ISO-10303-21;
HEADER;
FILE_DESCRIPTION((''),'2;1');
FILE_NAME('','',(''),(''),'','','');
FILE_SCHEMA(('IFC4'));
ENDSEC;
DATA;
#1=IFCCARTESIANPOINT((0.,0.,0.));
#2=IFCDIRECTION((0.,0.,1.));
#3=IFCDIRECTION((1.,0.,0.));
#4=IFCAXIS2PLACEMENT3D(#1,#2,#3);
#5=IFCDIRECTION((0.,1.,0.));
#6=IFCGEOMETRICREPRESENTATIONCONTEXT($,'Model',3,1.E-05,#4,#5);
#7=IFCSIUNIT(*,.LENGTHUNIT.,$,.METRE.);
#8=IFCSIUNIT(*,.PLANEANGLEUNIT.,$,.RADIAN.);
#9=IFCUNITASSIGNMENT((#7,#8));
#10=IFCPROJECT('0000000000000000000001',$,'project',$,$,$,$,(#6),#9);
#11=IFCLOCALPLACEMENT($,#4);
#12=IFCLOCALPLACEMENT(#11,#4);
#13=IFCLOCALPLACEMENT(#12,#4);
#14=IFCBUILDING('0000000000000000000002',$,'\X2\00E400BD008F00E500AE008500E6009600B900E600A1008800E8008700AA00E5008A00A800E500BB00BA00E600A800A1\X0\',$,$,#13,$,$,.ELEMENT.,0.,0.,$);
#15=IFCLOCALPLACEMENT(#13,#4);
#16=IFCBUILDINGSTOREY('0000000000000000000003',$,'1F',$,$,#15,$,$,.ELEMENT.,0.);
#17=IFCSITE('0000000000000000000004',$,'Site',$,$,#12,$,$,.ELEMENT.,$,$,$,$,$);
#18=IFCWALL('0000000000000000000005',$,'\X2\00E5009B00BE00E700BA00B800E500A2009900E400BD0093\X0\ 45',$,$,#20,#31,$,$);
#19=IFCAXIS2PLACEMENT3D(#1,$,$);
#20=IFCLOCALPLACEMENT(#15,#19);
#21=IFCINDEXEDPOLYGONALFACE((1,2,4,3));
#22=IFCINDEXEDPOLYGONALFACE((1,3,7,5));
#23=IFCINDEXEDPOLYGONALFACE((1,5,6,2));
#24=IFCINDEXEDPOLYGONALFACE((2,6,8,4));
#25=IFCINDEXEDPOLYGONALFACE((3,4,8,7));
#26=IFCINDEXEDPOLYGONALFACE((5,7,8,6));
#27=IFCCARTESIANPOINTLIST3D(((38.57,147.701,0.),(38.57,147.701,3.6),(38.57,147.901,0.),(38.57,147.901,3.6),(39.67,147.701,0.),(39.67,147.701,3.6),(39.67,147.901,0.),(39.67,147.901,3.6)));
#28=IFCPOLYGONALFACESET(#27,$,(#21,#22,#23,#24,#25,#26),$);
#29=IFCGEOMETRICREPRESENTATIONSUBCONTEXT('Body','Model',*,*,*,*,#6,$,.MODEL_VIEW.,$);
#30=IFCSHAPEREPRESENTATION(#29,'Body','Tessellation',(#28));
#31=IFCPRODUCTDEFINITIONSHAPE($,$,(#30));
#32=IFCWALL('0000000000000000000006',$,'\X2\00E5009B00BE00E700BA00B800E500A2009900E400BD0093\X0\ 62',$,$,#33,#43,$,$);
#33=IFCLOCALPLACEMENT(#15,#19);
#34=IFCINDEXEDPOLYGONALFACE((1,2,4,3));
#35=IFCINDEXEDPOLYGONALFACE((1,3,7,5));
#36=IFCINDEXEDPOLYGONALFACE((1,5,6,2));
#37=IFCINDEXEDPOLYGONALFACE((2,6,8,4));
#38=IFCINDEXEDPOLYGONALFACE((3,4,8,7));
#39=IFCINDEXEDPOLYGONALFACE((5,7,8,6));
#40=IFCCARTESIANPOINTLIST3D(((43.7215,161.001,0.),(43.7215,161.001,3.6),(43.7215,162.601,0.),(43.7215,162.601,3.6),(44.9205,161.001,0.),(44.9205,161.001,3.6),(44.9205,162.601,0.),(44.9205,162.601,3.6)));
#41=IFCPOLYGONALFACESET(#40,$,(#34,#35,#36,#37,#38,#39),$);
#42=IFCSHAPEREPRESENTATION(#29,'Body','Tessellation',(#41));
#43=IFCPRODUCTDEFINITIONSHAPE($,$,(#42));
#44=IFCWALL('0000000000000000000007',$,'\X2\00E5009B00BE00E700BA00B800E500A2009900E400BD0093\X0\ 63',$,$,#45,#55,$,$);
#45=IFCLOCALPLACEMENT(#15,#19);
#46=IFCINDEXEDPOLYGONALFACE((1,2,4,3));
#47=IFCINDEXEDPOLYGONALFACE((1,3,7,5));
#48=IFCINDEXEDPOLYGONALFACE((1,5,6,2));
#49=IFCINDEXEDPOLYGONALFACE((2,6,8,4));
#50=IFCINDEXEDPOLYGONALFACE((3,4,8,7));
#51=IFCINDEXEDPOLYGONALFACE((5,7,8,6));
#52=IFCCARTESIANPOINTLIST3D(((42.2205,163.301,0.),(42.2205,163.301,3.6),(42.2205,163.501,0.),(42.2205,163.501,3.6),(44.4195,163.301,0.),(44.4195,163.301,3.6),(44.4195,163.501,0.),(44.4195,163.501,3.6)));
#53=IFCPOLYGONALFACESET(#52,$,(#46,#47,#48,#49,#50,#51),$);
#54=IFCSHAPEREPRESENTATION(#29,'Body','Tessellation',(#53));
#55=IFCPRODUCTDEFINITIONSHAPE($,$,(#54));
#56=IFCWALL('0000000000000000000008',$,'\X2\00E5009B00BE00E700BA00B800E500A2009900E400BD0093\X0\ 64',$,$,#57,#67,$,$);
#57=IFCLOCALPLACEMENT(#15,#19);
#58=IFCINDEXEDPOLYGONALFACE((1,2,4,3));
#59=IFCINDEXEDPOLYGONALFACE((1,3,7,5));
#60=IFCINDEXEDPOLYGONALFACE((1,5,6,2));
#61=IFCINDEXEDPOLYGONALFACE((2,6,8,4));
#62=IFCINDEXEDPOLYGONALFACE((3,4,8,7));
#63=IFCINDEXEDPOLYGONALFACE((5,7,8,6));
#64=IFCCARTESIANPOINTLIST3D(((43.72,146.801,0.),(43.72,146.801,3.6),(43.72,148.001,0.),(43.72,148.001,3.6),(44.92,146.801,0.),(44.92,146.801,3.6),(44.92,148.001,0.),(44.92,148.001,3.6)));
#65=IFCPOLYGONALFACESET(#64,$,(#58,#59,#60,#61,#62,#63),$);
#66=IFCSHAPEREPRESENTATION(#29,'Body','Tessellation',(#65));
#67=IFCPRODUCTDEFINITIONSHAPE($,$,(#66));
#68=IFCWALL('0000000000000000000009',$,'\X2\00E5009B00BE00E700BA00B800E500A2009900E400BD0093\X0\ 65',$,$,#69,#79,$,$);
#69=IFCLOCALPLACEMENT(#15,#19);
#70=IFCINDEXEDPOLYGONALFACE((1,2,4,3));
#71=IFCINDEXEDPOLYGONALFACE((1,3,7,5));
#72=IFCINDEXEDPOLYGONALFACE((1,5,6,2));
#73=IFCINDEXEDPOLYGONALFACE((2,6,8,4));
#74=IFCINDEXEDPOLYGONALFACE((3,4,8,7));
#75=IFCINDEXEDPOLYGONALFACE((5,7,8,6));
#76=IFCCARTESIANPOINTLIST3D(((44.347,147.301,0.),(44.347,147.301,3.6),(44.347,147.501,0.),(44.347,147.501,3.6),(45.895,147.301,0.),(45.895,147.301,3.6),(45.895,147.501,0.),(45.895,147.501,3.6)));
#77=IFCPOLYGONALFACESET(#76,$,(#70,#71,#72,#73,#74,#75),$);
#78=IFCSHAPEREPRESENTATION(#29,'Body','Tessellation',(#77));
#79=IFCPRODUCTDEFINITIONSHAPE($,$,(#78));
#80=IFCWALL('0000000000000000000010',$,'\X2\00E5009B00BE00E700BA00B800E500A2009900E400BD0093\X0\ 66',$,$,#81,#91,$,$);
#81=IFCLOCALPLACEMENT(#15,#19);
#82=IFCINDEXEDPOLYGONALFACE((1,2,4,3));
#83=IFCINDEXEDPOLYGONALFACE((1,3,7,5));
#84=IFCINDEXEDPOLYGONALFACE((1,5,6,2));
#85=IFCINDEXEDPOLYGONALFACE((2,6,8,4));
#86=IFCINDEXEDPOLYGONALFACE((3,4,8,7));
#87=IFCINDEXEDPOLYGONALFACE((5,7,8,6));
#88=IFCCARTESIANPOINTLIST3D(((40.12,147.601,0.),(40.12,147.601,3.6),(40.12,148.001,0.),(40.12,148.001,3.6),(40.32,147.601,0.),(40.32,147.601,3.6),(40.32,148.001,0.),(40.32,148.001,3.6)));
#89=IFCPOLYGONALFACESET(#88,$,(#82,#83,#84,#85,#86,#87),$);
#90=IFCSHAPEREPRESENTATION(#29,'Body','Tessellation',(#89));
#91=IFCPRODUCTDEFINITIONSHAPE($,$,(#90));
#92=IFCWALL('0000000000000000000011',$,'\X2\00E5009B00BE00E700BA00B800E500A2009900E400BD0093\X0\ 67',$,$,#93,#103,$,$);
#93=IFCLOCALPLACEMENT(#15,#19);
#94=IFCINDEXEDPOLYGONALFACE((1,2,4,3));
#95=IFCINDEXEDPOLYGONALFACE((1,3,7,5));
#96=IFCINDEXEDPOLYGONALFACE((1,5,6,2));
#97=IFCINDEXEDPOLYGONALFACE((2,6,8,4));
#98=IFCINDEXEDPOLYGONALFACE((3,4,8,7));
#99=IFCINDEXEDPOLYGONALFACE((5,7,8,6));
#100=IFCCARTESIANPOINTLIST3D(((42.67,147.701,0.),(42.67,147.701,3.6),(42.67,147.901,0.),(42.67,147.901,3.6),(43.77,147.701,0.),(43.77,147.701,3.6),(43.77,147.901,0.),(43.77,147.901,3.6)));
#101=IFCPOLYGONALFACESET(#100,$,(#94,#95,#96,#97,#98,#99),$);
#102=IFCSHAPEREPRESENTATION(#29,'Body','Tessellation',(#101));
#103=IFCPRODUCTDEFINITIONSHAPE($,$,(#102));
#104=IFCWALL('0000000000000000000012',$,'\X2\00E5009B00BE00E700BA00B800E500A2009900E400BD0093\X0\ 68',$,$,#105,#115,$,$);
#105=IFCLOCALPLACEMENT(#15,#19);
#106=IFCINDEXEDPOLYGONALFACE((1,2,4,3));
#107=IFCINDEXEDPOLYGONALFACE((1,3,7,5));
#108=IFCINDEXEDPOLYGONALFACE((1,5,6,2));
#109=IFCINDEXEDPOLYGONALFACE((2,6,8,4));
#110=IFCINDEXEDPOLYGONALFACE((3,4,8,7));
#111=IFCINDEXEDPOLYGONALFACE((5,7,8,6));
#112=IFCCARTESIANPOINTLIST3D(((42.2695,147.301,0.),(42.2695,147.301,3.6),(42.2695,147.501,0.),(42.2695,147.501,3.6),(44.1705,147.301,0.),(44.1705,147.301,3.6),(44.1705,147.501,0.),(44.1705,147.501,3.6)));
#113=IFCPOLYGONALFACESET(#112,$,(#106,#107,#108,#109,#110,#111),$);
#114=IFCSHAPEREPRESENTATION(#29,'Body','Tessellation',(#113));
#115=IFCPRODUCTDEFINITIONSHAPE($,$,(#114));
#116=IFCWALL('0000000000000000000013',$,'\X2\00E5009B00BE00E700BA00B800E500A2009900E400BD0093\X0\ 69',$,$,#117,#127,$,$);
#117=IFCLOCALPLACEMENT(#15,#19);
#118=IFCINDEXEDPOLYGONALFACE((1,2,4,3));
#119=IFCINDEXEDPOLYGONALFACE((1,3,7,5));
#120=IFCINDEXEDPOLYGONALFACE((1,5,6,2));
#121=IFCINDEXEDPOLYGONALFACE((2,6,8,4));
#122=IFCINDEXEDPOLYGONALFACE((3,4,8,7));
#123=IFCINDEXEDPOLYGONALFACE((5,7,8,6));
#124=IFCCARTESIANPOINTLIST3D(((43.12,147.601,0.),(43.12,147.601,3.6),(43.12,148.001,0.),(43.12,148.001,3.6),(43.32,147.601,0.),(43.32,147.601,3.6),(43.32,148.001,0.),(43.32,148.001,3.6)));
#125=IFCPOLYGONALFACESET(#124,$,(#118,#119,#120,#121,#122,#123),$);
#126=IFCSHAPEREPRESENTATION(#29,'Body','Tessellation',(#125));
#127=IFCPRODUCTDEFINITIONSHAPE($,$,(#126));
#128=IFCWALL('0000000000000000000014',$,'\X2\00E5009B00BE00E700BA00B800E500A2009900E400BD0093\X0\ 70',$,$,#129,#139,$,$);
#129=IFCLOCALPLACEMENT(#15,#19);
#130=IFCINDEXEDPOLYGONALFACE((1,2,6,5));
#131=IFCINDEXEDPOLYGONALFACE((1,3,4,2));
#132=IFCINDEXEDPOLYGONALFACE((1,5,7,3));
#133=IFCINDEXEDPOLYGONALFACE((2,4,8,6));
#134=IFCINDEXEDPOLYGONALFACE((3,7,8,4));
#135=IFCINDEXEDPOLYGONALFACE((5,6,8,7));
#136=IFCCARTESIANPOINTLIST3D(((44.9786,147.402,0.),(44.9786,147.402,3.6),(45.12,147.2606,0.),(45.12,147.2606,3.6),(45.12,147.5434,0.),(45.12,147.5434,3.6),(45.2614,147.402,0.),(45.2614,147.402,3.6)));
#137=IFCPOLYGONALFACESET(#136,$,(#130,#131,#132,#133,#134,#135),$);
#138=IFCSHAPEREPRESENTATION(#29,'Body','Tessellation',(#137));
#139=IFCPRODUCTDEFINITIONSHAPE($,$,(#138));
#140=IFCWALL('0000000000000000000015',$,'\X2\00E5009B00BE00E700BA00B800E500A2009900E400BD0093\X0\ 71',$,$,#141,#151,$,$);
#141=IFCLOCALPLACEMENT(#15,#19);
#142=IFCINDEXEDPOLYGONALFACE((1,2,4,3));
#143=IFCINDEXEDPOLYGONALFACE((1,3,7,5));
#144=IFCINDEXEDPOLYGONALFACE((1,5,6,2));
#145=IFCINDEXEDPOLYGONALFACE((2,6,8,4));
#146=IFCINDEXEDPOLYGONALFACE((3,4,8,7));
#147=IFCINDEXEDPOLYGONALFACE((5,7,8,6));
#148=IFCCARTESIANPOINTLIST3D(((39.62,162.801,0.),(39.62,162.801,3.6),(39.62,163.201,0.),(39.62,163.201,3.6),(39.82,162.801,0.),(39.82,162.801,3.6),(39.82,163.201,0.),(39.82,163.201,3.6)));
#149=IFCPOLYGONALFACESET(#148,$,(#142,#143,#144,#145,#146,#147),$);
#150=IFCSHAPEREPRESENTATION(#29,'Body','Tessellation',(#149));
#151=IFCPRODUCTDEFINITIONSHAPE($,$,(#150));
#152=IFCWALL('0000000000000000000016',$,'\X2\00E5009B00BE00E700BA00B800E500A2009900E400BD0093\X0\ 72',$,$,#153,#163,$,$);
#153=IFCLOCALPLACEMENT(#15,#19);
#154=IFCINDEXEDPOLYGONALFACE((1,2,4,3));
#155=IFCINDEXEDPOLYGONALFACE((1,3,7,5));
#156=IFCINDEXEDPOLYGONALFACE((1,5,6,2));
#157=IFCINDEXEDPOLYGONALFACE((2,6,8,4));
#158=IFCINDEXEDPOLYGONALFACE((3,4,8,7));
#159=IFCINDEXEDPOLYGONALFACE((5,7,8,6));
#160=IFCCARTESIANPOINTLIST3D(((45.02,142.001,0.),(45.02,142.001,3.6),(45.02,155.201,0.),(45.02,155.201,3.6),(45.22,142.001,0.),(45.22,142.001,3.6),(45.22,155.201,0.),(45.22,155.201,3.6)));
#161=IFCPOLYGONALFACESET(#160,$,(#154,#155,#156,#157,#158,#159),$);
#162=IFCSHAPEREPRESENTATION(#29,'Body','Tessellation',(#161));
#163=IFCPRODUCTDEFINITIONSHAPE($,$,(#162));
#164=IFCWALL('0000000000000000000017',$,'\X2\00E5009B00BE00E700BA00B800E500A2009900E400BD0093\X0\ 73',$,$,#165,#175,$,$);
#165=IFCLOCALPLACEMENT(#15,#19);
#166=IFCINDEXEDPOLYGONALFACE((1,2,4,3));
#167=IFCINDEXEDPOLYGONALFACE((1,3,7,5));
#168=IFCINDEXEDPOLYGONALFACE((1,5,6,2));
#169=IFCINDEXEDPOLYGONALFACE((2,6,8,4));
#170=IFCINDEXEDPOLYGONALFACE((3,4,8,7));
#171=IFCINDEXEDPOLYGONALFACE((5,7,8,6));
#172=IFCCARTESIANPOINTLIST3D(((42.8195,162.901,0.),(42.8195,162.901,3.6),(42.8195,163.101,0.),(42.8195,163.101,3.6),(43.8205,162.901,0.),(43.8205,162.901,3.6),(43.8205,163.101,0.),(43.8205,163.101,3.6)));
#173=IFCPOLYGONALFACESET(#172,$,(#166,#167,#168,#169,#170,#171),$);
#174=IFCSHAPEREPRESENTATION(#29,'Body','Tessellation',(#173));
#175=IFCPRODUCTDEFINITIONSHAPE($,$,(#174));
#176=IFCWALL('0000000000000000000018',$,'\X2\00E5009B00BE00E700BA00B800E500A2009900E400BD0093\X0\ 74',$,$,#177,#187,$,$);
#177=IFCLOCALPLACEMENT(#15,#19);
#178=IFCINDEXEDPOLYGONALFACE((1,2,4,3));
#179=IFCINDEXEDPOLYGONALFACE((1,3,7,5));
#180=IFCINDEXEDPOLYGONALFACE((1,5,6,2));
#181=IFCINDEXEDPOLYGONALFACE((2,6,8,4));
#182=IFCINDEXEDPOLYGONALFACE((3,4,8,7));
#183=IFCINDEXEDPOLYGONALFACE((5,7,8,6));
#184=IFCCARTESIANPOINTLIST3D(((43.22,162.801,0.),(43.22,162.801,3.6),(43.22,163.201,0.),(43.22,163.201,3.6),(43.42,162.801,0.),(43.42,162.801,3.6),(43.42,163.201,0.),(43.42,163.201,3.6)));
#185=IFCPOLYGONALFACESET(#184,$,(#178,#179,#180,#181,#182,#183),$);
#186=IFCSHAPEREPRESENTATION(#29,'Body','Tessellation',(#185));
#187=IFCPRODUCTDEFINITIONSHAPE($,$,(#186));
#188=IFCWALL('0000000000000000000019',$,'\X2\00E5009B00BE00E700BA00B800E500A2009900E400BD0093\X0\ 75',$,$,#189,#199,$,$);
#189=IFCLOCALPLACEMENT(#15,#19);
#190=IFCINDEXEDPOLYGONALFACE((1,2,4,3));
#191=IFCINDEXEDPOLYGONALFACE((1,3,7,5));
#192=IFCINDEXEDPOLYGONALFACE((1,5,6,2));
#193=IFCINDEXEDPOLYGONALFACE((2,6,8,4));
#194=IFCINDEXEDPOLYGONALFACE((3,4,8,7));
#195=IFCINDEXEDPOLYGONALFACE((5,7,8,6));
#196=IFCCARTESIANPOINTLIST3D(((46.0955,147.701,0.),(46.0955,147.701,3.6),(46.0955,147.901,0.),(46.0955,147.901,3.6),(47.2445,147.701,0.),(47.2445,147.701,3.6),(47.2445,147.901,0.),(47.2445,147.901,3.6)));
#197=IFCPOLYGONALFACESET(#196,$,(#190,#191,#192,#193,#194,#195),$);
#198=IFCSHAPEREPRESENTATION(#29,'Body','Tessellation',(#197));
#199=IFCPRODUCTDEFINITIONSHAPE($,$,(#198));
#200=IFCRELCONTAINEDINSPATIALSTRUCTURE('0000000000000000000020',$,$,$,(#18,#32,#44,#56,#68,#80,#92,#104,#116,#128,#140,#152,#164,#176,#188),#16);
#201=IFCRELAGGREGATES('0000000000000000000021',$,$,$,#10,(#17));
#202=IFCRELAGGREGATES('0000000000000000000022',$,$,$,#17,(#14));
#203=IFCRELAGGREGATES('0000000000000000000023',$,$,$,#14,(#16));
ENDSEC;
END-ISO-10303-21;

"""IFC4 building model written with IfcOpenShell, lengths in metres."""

from ifc_helpers import new_model, si_unit, direction, frame, frame_2d, origin_with_axes, place, context, subcontext, project, spatial, rectangle, extrude, element, save


model = new_model("IFC4")

# Units and contexts
model_context = context("Model", 3, precision=1e-05, world=origin_with_axes(), true_north=direction((0.0, 1.0, 0.0)))
body_context = subcontext(model_context, "Body", "Model", "MODEL_VIEW")
ifc_project = project(units=[si_unit("LENGTHUNIT", "METRE"), si_unit("PLANEANGLEUNIT", "RADIAN")], contexts=[model_context])

# Site, building, storey
placement = place(None, origin_with_axes())
site_placement = place(placement, origin_with_axes())
site = spatial("IfcSite", under=ifc_project, at=site_placement, Name="Site", CompositionType="ELEMENT")
building_placement = place(site_placement, origin_with_axes())
building = spatial("IfcBuilding", under=site, at=building_placement, Name="ä½\u008få®\u0085æ\u0096¹æ¡\u0088è\u0087ªå\u008a¨å»ºæ¨¡", CompositionType="ELEMENT", ElevationOfRefHeight=0.0, ElevationOfTerrain=0.0)
storey_placement = place(building_placement, origin_with_axes())
storey = spatial("IfcBuildingStorey", under=building, at=storey_placement, Name="1F", CompositionType="ELEMENT", Elevation=0.0)

# Walls
wall_1_placement = place(storey_placement, frame((39.12, 147.801, 0.0), z_axis=(0.0, 0.0, 1.0), x_axis=(1.0, 0.0, 0.0)))
element("IfcWall", 1, at=wall_1_placement, inside=storey, Name="å\u009b¾çº¸å¢\u0099ä½\u0093 45", context=body_context, shape_type="SweptSolid", body=[
    extrude(rectangle(XDim=1.1, YDim=0.2, at=frame_2d((0.0, 0.0), x_axis=(1.0, 0.0, 0.0))), frame((0.0, 0.0, 0.0), z_axis=(0.0, 0.0, 1.0)), (0.0, 0.0, 1.0), 3.6),
])
wall_2_placement = place(storey_placement, frame((44.321, 161.801, 0.0), z_axis=(0.0, 0.0, 1.0), x_axis=(1.0, 0.0, 0.0)))
element("IfcWall", 2, at=wall_2_placement, inside=storey, Name="å\u009b¾çº¸å¢\u0099ä½\u0093 62", context=body_context, shape_type="SweptSolid", body=[
    extrude(rectangle(XDim=1.199, YDim=1.6, at=frame_2d((0.0, 0.0), x_axis=(1.0, 0.0, 0.0))), frame((0.0, 0.0, 0.0), z_axis=(0.0, 0.0, 1.0)), (0.0, 0.0, 1.0), 3.6),
])
wall_3_placement = place(storey_placement, frame((43.32, 163.401, 0.0), z_axis=(0.0, 0.0, 1.0), x_axis=(1.0, 0.0, 0.0)))
element("IfcWall", 3, at=wall_3_placement, inside=storey, Name="å\u009b¾çº¸å¢\u0099ä½\u0093 63", context=body_context, shape_type="SweptSolid", body=[
    extrude(rectangle(XDim=2.199, YDim=0.2, at=frame_2d((0.0, 0.0), x_axis=(1.0, 0.0, 0.0))), frame((0.0, 0.0, 0.0), z_axis=(0.0, 0.0, 1.0)), (0.0, 0.0, 1.0), 3.6),
])
wall_4_placement = place(storey_placement, frame((44.32, 147.401, 0.0), z_axis=(0.0, 0.0, 1.0), x_axis=(1.0, 0.0, 0.0)))
element("IfcWall", 4, at=wall_4_placement, inside=storey, Name="å\u009b¾çº¸å¢\u0099ä½\u0093 64", context=body_context, shape_type="SweptSolid", body=[
    extrude(rectangle(XDim=1.2, YDim=1.2, at=frame_2d((0.0, 0.0), x_axis=(1.0, 0.0, 0.0))), frame((0.0, 0.0, 0.0), z_axis=(0.0, 0.0, 1.0)), (0.0, 0.0, 1.0), 3.6),
])
wall_5_placement = place(storey_placement, frame((45.121, 147.401, 0.0), z_axis=(0.0, 0.0, 1.0), x_axis=(1.0, 0.0, 0.0)))
element("IfcWall", 5, at=wall_5_placement, inside=storey, Name="å\u009b¾çº¸å¢\u0099ä½\u0093 65", context=body_context, shape_type="SweptSolid", body=[
    extrude(rectangle(XDim=1.548, YDim=0.2, at=frame_2d((0.0, 0.0), x_axis=(1.0, 0.0, 0.0))), frame((0.0, 0.0, 0.0), z_axis=(0.0, 0.0, 1.0)), (0.0, 0.0, 1.0), 3.6),
])
wall_6_placement = place(storey_placement, frame((40.22, 147.801, 0.0), z_axis=(0.0, 0.0, 1.0), x_axis=(0.0, -1.0, 0.0)))
element("IfcWall", 6, at=wall_6_placement, inside=storey, Name="å\u009b¾çº¸å¢\u0099ä½\u0093 66", context=body_context, shape_type="SweptSolid", body=[
    extrude(rectangle(XDim=0.4, YDim=0.2, at=frame_2d((0.0, 0.0), x_axis=(1.0, 0.0, 0.0))), frame((0.0, 0.0, 0.0), z_axis=(0.0, 0.0, 1.0)), (0.0, 0.0, 1.0), 3.6),
])
wall_7_placement = place(storey_placement, frame((43.22, 147.801, 0.0), z_axis=(0.0, 0.0, 1.0), x_axis=(1.0, 0.0, 0.0)))
element("IfcWall", 7, at=wall_7_placement, inside=storey, Name="å\u009b¾çº¸å¢\u0099ä½\u0093 67", context=body_context, shape_type="SweptSolid", body=[
    extrude(rectangle(XDim=1.1, YDim=0.2, at=frame_2d((0.0, 0.0), x_axis=(1.0, 0.0, 0.0))), frame((0.0, 0.0, 0.0), z_axis=(0.0, 0.0, 1.0)), (0.0, 0.0, 1.0), 3.6),
])
wall_8_placement = place(storey_placement, frame((43.22, 147.401, 0.0), z_axis=(0.0, 0.0, 1.0), x_axis=(1.0, 0.0, 0.0)))
element("IfcWall", 8, at=wall_8_placement, inside=storey, Name="å\u009b¾çº¸å¢\u0099ä½\u0093 68", context=body_context, shape_type="SweptSolid", body=[
    extrude(rectangle(XDim=1.901, YDim=0.2, at=frame_2d((0.0, 0.0), x_axis=(1.0, 0.0, 0.0))), frame((0.0, 0.0, 0.0), z_axis=(0.0, 0.0, 1.0)), (0.0, 0.0, 1.0), 3.6),
])
wall_9_placement = place(storey_placement, frame((43.22, 147.801, 0.0), z_axis=(0.0, 0.0, 1.0), x_axis=(0.0, -1.0, 0.0)))
element("IfcWall", 9, at=wall_9_placement, inside=storey, Name="å\u009b¾çº¸å¢\u0099ä½\u0093 69", context=body_context, shape_type="SweptSolid", body=[
    extrude(rectangle(XDim=0.4, YDim=0.2, at=frame_2d((0.0, 0.0), x_axis=(1.0, 0.0, 0.0))), frame((0.0, 0.0, 0.0), z_axis=(0.0, 0.0, 1.0)), (0.0, 0.0, 1.0), 3.6),
])
wall_10_placement = place(storey_placement, frame((45.12, 147.402, 0.0), z_axis=(0.0, 0.0, 1.0), x_axis=(0.707107, -0.707107, 0.0)))
element("IfcWall", 10, at=wall_10_placement, inside=storey, Name="å\u009b¾çº¸å¢\u0099ä½\u0093 70", context=body_context, shape_type="SweptSolid", body=[
    extrude(rectangle(XDim=0.2, YDim=0.2, at=frame_2d((0.0, 0.0), x_axis=(1.0, 0.0, 0.0))), frame((0.0, 0.0, 0.0), z_axis=(0.0, 0.0, 1.0)), (0.0, 0.0, 1.0), 3.6),
])
wall_11_placement = place(storey_placement, frame((39.72, 163.001, 0.0), z_axis=(0.0, 0.0, 1.0), x_axis=(0.0, 1.0, 0.0)))
element("IfcWall", 11, at=wall_11_placement, inside=storey, Name="å\u009b¾çº¸å¢\u0099ä½\u0093 71", context=body_context, shape_type="SweptSolid", body=[
    extrude(rectangle(XDim=0.4, YDim=0.2, at=frame_2d((0.0, 0.0), x_axis=(1.0, 0.0, 0.0))), frame((0.0, 0.0, 0.0), z_axis=(0.0, 0.0, 1.0)), (0.0, 0.0, 1.0), 3.6),
])
wall_12_placement = place(storey_placement, frame((45.12, 148.601, 0.0), z_axis=(0.0, 0.0, 1.0), x_axis=(0.0, 1.0, 0.0)))
element("IfcWall", 12, at=wall_12_placement, inside=storey, Name="å\u009b¾çº¸å¢\u0099ä½\u0093 72", context=body_context, shape_type="SweptSolid", body=[
    extrude(rectangle(XDim=13.2, YDim=0.2, at=frame_2d((0.0, 0.0), x_axis=(1.0, 0.0, 0.0))), frame((0.0, 0.0, 0.0), z_axis=(0.0, 0.0, 1.0)), (0.0, 0.0, 1.0), 3.6),
])
wall_13_placement = place(storey_placement, frame((43.32, 163.001, 0.0), z_axis=(0.0, 0.0, 1.0), x_axis=(1.0, 0.0, 0.0)))
element("IfcWall", 13, at=wall_13_placement, inside=storey, Name="å\u009b¾çº¸å¢\u0099ä½\u0093 73", context=body_context, shape_type="SweptSolid", body=[
    extrude(rectangle(XDim=1.001, YDim=0.2, at=frame_2d((0.0, 0.0), x_axis=(1.0, 0.0, 0.0))), frame((0.0, 0.0, 0.0), z_axis=(0.0, 0.0, 1.0)), (0.0, 0.0, 1.0), 3.6),
])
wall_14_placement = place(storey_placement, frame((43.32, 163.001, 0.0), z_axis=(0.0, 0.0, 1.0), x_axis=(0.0, 1.0, 0.0)))
element("IfcWall", 14, at=wall_14_placement, inside=storey, Name="å\u009b¾çº¸å¢\u0099ä½\u0093 74", context=body_context, shape_type="SweptSolid", body=[
    extrude(rectangle(XDim=0.4, YDim=0.2, at=frame_2d((0.0, 0.0), x_axis=(1.0, 0.0, 0.0))), frame((0.0, 0.0, 0.0), z_axis=(0.0, 0.0, 1.0)), (0.0, 0.0, 1.0), 3.6),
])
wall_15_placement = place(storey_placement, frame((46.67, 147.801, 0.0), z_axis=(0.0, 0.0, 1.0), x_axis=(-1.0, 0.0, 0.0)))
element("IfcWall", 15, at=wall_15_placement, inside=storey, Name="å\u009b¾çº¸å¢\u0099ä½\u0093 75", context=body_context, shape_type="SweptSolid", body=[
    extrude(rectangle(XDim=1.149, YDim=0.2, at=frame_2d((0.0, 0.0), x_axis=(1.0, 0.0, 0.0))), frame((0.0, 0.0, 0.0), z_axis=(0.0, 0.0, 1.0)), (0.0, 0.0, 1.0), 3.6),
])

save(model, "model.ifc")
